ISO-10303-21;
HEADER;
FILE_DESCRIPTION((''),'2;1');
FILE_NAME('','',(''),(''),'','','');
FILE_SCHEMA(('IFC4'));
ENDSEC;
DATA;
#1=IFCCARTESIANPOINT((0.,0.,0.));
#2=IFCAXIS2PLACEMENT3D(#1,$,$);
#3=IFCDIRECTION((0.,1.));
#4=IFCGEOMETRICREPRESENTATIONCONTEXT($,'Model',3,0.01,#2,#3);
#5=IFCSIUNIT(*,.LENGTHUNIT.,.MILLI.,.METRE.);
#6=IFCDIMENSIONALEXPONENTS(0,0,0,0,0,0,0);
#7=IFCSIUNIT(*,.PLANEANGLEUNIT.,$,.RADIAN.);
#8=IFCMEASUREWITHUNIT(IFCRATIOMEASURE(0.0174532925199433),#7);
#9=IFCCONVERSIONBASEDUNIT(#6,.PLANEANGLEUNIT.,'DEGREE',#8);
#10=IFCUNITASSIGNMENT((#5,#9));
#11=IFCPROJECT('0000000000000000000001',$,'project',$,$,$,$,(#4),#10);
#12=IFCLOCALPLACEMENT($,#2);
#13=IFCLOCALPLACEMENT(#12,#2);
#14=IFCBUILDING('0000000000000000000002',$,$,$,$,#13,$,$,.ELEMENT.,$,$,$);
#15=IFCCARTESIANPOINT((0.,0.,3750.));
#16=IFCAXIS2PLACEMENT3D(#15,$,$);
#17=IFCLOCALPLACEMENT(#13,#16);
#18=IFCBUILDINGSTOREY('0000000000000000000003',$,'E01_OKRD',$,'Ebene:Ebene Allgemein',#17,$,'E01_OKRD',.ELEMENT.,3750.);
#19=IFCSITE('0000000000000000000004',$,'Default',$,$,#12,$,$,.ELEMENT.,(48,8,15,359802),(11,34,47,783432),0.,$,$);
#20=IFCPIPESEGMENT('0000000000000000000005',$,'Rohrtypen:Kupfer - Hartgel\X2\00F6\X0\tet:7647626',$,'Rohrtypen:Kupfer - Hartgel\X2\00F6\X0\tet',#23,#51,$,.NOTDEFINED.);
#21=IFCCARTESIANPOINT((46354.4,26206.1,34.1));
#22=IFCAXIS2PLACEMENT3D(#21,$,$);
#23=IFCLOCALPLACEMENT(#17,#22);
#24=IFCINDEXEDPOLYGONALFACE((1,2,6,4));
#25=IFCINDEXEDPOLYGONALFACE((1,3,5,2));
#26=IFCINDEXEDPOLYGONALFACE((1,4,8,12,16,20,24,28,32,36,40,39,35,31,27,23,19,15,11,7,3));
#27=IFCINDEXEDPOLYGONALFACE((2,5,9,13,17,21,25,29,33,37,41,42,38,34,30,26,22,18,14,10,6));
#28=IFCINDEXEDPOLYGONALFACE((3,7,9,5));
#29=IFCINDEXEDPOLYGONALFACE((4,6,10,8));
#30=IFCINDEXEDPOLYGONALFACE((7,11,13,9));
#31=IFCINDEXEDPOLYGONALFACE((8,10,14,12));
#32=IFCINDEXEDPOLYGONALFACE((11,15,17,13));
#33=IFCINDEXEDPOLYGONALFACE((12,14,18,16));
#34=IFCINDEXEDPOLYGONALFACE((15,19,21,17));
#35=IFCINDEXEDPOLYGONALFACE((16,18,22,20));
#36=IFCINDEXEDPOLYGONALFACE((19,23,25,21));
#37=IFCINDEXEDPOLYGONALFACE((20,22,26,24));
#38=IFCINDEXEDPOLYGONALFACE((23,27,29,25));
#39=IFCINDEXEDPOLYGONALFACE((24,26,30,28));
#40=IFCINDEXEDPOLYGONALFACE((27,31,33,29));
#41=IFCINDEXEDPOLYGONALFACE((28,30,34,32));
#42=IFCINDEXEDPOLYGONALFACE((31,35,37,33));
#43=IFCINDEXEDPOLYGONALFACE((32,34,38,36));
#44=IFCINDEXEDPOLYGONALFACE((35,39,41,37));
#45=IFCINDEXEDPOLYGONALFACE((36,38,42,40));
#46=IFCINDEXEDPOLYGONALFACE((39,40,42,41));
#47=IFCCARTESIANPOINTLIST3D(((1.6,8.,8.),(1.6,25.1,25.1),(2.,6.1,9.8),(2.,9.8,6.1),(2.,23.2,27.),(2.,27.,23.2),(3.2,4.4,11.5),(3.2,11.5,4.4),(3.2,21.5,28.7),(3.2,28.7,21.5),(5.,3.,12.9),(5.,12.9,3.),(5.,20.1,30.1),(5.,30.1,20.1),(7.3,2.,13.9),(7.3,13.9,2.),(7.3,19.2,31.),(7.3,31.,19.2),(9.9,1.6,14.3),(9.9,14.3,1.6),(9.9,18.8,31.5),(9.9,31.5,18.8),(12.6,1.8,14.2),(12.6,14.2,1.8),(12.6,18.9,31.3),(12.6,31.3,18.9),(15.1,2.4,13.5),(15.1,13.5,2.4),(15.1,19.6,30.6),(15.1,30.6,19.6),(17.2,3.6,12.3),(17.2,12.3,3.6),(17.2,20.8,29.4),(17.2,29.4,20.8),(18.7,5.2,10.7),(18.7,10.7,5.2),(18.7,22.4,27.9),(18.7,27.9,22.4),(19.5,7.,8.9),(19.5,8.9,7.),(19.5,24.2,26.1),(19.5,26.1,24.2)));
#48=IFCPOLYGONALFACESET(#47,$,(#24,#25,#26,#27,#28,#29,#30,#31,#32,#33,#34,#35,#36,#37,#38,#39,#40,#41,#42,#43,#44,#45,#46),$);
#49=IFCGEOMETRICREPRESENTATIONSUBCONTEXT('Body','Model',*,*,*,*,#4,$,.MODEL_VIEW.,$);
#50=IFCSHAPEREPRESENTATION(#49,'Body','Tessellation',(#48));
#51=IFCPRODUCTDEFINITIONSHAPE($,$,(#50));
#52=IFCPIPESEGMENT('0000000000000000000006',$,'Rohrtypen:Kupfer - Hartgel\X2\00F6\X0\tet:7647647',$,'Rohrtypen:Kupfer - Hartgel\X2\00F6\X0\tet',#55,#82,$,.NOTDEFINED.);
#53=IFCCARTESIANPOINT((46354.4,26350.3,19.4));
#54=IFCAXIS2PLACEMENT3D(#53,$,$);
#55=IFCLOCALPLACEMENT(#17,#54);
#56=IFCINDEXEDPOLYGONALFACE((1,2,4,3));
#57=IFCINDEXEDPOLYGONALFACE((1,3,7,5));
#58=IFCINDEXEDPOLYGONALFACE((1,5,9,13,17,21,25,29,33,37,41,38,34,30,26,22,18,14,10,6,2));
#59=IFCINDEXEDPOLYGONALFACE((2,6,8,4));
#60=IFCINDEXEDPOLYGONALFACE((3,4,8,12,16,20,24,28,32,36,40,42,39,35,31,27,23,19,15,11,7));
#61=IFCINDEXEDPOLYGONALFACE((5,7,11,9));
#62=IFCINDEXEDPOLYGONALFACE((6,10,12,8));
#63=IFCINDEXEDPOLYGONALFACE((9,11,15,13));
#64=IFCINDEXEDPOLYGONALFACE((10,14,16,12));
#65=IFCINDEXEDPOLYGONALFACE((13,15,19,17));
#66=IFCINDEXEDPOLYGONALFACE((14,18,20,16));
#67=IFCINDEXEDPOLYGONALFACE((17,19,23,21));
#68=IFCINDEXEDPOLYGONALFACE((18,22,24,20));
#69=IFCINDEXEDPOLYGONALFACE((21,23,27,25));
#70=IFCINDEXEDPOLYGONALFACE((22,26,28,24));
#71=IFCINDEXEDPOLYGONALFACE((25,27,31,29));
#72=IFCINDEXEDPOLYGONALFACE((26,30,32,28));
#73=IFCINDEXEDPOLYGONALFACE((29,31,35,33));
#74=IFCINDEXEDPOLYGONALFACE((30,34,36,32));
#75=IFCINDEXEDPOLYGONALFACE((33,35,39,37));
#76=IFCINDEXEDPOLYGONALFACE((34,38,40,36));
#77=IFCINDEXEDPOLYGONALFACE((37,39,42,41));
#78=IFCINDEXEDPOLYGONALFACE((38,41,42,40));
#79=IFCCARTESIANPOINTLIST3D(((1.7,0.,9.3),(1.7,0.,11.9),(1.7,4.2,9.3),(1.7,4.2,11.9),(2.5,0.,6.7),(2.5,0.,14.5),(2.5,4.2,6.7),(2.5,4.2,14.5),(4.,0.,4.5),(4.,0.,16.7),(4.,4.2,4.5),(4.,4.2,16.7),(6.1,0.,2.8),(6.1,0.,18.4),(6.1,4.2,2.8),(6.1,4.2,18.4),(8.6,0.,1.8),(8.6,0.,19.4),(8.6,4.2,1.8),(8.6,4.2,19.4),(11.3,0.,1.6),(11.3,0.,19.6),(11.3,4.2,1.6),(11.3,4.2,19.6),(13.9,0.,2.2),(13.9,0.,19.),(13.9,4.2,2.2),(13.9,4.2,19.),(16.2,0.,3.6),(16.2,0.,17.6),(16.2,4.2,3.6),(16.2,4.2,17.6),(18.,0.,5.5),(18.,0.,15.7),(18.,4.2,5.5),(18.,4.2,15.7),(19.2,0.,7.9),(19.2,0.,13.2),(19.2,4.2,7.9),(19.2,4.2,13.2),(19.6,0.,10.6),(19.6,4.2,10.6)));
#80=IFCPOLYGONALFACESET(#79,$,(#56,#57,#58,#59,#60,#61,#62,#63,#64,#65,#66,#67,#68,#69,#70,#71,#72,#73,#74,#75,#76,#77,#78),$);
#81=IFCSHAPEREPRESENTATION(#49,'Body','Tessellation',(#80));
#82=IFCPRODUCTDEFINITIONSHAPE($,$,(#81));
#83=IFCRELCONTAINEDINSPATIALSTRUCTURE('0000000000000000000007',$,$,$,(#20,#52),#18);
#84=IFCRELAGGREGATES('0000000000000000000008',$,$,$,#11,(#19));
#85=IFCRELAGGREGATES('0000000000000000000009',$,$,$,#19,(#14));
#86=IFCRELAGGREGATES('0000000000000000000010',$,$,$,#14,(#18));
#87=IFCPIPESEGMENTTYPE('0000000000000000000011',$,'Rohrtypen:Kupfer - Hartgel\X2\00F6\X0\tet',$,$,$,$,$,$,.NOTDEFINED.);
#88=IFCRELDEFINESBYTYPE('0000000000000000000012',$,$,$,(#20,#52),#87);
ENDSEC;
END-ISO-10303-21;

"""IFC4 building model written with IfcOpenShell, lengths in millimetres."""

from ifc_helpers import new_model, entity, si_unit, converted_unit, direction, frame, frame_2d, origin, origin_2d_with_axis, place, context, subcontext, project, spatial, circle, extrude, type_object, element, save


model = new_model("IFC4")

# Units and contexts
model_context = context("Model", 3, precision=0.01, world=origin(), true_north=direction((0.0, 1.0)))
body_context = subcontext(model_context, "Body", "Model", "MODEL_VIEW")
ifc_project = project(units=[si_unit("LENGTHUNIT", "METRE", prefix="MILLI"), converted_unit("PLANEANGLEUNIT", "DEGREE", entity("IfcRatioMeasure", 0.0174532925199433), si_unit("PLANEANGLEUNIT", "RADIAN"), dimensions=[0, 0, 0, 0, 0, 0, 0])], contexts=[model_context])

# Site, building, storey
site_placement = place(None, origin())
site = spatial("IfcSite", under=ifc_project, at=site_placement, Name="Default", CompositionType="ELEMENT", RefLatitude=(48, 8, 15, 359802), RefLongitude=(11, 34, 47, 783432), RefElevation=0.0)
building_placement = place(site_placement, origin())
building = spatial("IfcBuilding", under=site, at=building_placement, CompositionType="ELEMENT")
storey_placement = place(building_placement, frame((0.0, 0.0, 3750.0)))
storey = spatial("IfcBuildingStorey", under=building, at=storey_placement, Name="E01_OKRD", ObjectType="Ebene:Ebene Allgemein", LongName="E01_OKRD", CompositionType="ELEMENT", Elevation=3750.0)

# Pipe segments
pipe_segment_type = type_object("IfcPipeSegmentType", Name="Rohrtypen:Kupfer - Hartgelötet", PredefinedType="NOTDEFINED")
pipe_segment_1_placement = place(storey_placement, frame((46354.4, 26206.1, 34.1)))
element("IfcPipeSegment", 1, at=pipe_segment_1_placement, inside=storey, type_object=pipe_segment_type, Name="Rohrtypen:Kupfer - Hartgelötet:7647626", ObjectType="Rohrtypen:Kupfer - Hartgelötet", PredefinedType="NOTDEFINED", context=body_context, shape_type="SweptSolid", body=[
    extrude(circle(Radius=9.0, at=frame_2d((0.0, 0.0), x_axis=(1.0, 0.0))), frame((10.6, 8.0, 8.0), z_axis=(0.0, 0.707107, 0.707107), x_axis=(-1.0, 0.0, 0.0)), (0.0, 0.0, 1.0), 24.3),
])
pipe_segment_2_placement = place(storey_placement, frame((46354.4, 26350.3, 19.4)))
element("IfcPipeSegment", 2, at=pipe_segment_2_placement, inside=storey, type_object=pipe_segment_type, Name="Rohrtypen:Kupfer - Hartgelötet:7647647", ObjectType="Rohrtypen:Kupfer - Hartgelötet", PredefinedType="NOTDEFINED", context=body_context, shape_type="SweptSolid", body=[
    extrude(circle(Radius=9.0, at=origin_2d_with_axis()), frame((10.6, 0.0, 10.6), z_axis=(0.0, 1.0, 0.0), x_axis=(1.0, 0.0, 0.0)), (0.0, 0.0, 1.0), 4.2),
])

save(model, "model.ifc")
